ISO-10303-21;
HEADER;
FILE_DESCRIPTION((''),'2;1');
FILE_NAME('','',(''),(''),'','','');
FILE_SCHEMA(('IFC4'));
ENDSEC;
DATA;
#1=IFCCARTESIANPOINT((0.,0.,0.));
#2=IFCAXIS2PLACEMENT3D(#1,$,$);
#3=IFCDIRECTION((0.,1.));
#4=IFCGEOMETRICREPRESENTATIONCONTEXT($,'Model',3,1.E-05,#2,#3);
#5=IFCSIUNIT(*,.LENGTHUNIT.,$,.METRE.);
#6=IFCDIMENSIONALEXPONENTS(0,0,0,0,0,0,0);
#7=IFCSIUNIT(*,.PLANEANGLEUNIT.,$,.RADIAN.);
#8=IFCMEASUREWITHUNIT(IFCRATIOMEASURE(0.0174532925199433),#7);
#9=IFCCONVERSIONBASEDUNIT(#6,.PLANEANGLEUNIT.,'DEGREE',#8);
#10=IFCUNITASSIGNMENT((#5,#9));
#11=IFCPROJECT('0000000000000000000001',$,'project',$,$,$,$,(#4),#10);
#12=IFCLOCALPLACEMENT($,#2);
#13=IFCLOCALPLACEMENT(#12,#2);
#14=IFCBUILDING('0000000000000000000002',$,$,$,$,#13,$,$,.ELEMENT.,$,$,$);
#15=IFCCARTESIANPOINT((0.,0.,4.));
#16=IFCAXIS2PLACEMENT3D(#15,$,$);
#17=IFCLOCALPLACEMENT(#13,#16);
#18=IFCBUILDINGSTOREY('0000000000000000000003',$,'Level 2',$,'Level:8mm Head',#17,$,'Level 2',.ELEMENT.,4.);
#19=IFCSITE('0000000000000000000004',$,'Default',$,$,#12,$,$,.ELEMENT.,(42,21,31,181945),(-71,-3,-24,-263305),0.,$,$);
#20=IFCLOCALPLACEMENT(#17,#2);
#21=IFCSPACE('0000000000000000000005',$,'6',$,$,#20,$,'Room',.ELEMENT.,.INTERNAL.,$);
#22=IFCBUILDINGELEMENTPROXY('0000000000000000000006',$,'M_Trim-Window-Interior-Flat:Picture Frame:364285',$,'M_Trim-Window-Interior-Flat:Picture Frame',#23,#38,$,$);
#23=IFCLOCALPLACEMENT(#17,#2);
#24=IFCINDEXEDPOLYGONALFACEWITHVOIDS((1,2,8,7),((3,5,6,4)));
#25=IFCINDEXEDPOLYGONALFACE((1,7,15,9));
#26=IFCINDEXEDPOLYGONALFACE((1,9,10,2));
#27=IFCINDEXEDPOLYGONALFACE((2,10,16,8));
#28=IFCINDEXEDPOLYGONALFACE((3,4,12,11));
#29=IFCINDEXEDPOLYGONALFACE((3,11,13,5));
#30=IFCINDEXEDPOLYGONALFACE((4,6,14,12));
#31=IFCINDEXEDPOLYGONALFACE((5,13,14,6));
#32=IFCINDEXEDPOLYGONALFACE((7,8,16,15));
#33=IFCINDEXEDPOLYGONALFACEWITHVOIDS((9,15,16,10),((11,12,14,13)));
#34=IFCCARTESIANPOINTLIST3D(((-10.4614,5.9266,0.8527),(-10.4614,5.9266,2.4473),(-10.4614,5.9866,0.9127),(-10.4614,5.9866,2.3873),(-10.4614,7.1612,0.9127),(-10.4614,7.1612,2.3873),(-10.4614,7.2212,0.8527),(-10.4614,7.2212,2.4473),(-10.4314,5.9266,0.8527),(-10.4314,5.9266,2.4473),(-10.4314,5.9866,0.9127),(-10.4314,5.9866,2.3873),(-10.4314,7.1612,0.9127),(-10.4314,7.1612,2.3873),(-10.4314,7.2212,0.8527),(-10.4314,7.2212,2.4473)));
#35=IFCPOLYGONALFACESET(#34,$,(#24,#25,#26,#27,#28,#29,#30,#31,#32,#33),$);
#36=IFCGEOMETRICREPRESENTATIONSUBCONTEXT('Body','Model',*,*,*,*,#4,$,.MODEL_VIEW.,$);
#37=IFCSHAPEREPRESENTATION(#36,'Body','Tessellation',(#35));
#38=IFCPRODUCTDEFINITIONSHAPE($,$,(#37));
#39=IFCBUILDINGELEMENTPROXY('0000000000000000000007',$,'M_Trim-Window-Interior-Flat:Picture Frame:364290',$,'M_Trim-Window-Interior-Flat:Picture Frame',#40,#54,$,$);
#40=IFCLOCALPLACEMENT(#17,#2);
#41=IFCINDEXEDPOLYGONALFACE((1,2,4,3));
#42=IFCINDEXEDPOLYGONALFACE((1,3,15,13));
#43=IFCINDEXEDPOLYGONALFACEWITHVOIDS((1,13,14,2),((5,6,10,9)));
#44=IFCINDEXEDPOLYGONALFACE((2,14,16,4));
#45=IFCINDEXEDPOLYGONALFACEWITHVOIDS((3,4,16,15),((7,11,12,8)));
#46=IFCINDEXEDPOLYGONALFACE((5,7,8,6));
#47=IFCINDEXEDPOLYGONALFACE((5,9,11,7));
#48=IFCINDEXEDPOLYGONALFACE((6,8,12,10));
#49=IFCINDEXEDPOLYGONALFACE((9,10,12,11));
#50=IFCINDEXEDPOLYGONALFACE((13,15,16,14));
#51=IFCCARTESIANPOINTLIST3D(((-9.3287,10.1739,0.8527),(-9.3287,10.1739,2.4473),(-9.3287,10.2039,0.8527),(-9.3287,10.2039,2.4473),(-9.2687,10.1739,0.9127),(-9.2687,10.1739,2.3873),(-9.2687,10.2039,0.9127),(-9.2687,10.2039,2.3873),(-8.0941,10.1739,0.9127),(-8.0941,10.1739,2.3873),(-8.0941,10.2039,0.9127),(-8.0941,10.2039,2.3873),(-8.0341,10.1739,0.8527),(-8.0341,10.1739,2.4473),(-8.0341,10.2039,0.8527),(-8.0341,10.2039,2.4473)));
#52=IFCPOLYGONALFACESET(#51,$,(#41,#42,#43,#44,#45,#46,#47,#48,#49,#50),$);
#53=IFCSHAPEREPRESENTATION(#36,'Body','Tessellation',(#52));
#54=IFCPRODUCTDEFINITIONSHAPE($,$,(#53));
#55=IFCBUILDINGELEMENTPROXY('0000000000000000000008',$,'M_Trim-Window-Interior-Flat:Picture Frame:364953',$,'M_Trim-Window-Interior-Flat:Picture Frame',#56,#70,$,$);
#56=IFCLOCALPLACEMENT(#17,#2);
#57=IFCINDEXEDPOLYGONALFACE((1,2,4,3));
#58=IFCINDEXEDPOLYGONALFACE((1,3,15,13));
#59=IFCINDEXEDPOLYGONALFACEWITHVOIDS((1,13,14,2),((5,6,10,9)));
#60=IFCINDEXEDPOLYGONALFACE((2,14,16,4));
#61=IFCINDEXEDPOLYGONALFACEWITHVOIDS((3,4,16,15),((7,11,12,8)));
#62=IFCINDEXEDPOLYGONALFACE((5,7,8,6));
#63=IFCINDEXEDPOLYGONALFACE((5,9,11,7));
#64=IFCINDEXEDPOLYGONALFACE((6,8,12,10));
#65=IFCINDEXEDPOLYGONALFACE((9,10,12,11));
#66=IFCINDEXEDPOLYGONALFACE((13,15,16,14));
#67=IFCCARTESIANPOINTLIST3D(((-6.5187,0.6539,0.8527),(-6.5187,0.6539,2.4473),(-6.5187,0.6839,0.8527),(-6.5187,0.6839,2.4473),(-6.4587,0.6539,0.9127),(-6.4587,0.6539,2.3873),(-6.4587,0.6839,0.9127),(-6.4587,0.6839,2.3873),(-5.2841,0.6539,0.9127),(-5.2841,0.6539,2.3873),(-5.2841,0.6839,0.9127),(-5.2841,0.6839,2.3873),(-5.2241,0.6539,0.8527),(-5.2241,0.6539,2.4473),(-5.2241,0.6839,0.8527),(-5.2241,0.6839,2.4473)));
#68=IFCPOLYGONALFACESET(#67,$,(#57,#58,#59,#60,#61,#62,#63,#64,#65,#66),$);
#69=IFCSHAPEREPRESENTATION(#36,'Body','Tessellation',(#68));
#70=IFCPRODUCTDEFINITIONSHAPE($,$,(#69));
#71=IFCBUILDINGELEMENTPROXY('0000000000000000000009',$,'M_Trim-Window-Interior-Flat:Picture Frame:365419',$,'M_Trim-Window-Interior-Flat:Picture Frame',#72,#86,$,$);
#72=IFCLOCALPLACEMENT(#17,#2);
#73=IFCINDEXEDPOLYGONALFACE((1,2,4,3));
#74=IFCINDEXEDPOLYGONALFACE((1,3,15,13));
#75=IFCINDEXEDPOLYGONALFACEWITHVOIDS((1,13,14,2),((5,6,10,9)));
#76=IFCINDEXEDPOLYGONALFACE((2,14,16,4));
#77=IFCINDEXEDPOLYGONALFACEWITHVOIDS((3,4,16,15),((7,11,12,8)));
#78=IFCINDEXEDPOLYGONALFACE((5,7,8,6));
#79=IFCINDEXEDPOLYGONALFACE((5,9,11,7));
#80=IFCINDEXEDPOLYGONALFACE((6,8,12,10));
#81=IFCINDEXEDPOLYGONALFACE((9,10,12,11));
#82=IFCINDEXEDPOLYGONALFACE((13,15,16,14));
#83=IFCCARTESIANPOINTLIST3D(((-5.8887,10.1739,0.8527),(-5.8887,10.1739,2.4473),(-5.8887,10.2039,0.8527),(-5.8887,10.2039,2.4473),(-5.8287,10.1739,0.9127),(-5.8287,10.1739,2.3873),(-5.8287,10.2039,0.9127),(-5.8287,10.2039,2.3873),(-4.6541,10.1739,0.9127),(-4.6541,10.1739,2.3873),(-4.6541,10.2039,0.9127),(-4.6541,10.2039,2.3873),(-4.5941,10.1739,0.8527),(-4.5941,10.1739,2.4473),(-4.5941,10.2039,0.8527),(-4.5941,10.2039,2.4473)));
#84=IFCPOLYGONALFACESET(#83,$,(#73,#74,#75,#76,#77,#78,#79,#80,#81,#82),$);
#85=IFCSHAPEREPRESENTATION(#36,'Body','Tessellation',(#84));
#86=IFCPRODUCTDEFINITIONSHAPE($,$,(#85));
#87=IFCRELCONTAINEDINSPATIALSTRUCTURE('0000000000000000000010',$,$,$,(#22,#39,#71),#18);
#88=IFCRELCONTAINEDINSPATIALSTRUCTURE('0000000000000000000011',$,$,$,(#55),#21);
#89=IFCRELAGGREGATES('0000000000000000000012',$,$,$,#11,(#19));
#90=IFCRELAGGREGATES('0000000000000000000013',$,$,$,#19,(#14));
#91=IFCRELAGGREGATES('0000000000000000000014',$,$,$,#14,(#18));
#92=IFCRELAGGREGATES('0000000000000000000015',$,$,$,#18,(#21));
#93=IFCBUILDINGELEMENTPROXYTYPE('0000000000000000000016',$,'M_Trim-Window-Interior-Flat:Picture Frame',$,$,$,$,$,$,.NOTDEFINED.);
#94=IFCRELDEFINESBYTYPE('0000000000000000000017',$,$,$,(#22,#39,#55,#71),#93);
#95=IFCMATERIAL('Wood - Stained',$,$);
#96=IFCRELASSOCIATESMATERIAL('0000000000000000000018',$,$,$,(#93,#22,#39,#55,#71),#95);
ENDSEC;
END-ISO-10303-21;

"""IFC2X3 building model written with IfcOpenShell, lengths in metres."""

from ifc_helpers import new_model, entity, si_unit, converted_unit, direction, frame, origin, place, context, subcontext, project, spatial, polyline, outline, extrude, source, transform, mapped, material, type_object, type_shapes, element, save


model = new_model("IFC2X3")

# Units and contexts
model_context = context("Model", 3, precision=1e-05, world=origin(), true_north=direction((0.0, 1.0)))
body_context = subcontext(model_context, "Body", "Model", "MODEL_VIEW")
ifc_project = project(units=[si_unit("LENGTHUNIT", "METRE"), converted_unit("PLANEANGLEUNIT", "DEGREE", entity("IfcRatioMeasure", 0.0174532925199433), si_unit("PLANEANGLEUNIT", "RADIAN"), dimensions=[0, 0, 0, 0, 0, 0, 0])], contexts=[model_context])

# Site, building, storey
site_placement = place(None, origin())
site = spatial("IfcSite", under=ifc_project, at=site_placement, Name="Default", CompositionType="ELEMENT", RefLatitude=(42, 21, 31, 181945), RefLongitude=(-71, -3, -24, -263305), RefElevation=0.0)
building_placement = place(site_placement, origin())
building = spatial("IfcBuilding", under=site, at=building_placement, CompositionType="ELEMENT")
storey_placement = place(building_placement, frame((0.0, 0.0, 4.0)))
storey = spatial("IfcBuildingStorey", under=building, at=storey_placement, Name="Level 2", ObjectType="Level:8mm Head", LongName="Level 2", CompositionType="ELEMENT", Elevation=4.0)

# Shared definitions
ifc_material_1 = material(Name="Wood - Stained")

# Building element proxies
building_element_proxy_type_1 = type_object("IfcBuildingElementProxyType", Name="M_Trim-Window-Interior-Flat:Picture Frame", PredefinedType="NOTDEFINED", material=ifc_material_1)
shared_shape_1 = source(origin(), body_context, "Body", "SweptSolid", [
    extrude(outline(polyline([(-0.6473, -0.7973), (0.6473, -0.7973), (0.6473, 0.7973), (-0.6473, 0.7973), (-0.6473, -0.7973)]), holes=[polyline([(-0.5873, -0.7373), (-0.5873, 0.7373), (0.5873, 0.7373), (0.5873, -0.7373), (-0.5873, -0.7373)])]), frame((0.0, -0.75, 0.0), z_axis=(0.0, 0.0, 1.0), x_axis=(-1.0, 0.0, 0.0)), (0.0, 0.0, 1.0), 0.03),
])
type_shapes(building_element_proxy_type_1, [shared_shape_1])
for number, where, z_axis, x_axis, name in (
    (1, (-10.4314, 6.5739, 2.4), (-1.0, 0.0, 0.0), (0.0, -1.0, 0.0), "M_Trim-Window-Interior-Flat:Picture Frame:364285"),
    (2, (-8.6814, 10.1739, 2.4), (0.0, 1.0, 0.0), (-1.0, 0.0, 0.0), "M_Trim-Window-Interior-Flat:Picture Frame:364290"),
):
    element("IfcBuildingElementProxy", number, at=place(storey_placement, frame(where, z_axis=z_axis, x_axis=x_axis)), inside=storey, type_object=building_element_proxy_type_1, material=ifc_material_1, Name=name, ObjectType="M_Trim-Window-Interior-Flat:Picture Frame", context=body_context, shape_type="MappedRepresentation", body=[
        mapped(shared_shape_1, transform((0.0, 0.0, 0.0), scale=1.0)),
    ])

# Shared definitions
space_1_placement = place(storey_placement, origin())
space_1 = spatial("IfcSpace", under=storey, at=space_1_placement, Name="6", LongName="Room", CompositionType="ELEMENT", InteriorOrExteriorSpace="INTERNAL")

# Building element proxies
proxy_1_placement = place(space_1_placement, frame((-5.8714, 0.6539, 2.4), z_axis=(0.0, 1.0, 0.0), x_axis=(-1.0, 0.0, 0.0)))
element("IfcBuildingElementProxy", 3, at=proxy_1_placement, inside=space_1, type_object=building_element_proxy_type_1, material=ifc_material_1, Name="M_Trim-Window-Interior-Flat:Picture Frame:364953", ObjectType="M_Trim-Window-Interior-Flat:Picture Frame", context=body_context, shape_type="MappedRepresentation", body=[
    mapped(shared_shape_1, transform((0.0, 0.0, 0.0), scale=1.0)),
])
proxy_2_placement = place(storey_placement, frame((-5.2414, 10.1739, 2.4), z_axis=(0.0, 1.0, 0.0), x_axis=(-1.0, 0.0, 0.0)))
element("IfcBuildingElementProxy", 4, at=proxy_2_placement, inside=storey, type_object=building_element_proxy_type_1, material=ifc_material_1, Name="M_Trim-Window-Interior-Flat:Picture Frame:365419", ObjectType="M_Trim-Window-Interior-Flat:Picture Frame", context=body_context, shape_type="MappedRepresentation", body=[
    mapped(shared_shape_1, transform((0.0, 0.0, 0.0), scale=1.0)),
])

save(model, "model.ifc")
